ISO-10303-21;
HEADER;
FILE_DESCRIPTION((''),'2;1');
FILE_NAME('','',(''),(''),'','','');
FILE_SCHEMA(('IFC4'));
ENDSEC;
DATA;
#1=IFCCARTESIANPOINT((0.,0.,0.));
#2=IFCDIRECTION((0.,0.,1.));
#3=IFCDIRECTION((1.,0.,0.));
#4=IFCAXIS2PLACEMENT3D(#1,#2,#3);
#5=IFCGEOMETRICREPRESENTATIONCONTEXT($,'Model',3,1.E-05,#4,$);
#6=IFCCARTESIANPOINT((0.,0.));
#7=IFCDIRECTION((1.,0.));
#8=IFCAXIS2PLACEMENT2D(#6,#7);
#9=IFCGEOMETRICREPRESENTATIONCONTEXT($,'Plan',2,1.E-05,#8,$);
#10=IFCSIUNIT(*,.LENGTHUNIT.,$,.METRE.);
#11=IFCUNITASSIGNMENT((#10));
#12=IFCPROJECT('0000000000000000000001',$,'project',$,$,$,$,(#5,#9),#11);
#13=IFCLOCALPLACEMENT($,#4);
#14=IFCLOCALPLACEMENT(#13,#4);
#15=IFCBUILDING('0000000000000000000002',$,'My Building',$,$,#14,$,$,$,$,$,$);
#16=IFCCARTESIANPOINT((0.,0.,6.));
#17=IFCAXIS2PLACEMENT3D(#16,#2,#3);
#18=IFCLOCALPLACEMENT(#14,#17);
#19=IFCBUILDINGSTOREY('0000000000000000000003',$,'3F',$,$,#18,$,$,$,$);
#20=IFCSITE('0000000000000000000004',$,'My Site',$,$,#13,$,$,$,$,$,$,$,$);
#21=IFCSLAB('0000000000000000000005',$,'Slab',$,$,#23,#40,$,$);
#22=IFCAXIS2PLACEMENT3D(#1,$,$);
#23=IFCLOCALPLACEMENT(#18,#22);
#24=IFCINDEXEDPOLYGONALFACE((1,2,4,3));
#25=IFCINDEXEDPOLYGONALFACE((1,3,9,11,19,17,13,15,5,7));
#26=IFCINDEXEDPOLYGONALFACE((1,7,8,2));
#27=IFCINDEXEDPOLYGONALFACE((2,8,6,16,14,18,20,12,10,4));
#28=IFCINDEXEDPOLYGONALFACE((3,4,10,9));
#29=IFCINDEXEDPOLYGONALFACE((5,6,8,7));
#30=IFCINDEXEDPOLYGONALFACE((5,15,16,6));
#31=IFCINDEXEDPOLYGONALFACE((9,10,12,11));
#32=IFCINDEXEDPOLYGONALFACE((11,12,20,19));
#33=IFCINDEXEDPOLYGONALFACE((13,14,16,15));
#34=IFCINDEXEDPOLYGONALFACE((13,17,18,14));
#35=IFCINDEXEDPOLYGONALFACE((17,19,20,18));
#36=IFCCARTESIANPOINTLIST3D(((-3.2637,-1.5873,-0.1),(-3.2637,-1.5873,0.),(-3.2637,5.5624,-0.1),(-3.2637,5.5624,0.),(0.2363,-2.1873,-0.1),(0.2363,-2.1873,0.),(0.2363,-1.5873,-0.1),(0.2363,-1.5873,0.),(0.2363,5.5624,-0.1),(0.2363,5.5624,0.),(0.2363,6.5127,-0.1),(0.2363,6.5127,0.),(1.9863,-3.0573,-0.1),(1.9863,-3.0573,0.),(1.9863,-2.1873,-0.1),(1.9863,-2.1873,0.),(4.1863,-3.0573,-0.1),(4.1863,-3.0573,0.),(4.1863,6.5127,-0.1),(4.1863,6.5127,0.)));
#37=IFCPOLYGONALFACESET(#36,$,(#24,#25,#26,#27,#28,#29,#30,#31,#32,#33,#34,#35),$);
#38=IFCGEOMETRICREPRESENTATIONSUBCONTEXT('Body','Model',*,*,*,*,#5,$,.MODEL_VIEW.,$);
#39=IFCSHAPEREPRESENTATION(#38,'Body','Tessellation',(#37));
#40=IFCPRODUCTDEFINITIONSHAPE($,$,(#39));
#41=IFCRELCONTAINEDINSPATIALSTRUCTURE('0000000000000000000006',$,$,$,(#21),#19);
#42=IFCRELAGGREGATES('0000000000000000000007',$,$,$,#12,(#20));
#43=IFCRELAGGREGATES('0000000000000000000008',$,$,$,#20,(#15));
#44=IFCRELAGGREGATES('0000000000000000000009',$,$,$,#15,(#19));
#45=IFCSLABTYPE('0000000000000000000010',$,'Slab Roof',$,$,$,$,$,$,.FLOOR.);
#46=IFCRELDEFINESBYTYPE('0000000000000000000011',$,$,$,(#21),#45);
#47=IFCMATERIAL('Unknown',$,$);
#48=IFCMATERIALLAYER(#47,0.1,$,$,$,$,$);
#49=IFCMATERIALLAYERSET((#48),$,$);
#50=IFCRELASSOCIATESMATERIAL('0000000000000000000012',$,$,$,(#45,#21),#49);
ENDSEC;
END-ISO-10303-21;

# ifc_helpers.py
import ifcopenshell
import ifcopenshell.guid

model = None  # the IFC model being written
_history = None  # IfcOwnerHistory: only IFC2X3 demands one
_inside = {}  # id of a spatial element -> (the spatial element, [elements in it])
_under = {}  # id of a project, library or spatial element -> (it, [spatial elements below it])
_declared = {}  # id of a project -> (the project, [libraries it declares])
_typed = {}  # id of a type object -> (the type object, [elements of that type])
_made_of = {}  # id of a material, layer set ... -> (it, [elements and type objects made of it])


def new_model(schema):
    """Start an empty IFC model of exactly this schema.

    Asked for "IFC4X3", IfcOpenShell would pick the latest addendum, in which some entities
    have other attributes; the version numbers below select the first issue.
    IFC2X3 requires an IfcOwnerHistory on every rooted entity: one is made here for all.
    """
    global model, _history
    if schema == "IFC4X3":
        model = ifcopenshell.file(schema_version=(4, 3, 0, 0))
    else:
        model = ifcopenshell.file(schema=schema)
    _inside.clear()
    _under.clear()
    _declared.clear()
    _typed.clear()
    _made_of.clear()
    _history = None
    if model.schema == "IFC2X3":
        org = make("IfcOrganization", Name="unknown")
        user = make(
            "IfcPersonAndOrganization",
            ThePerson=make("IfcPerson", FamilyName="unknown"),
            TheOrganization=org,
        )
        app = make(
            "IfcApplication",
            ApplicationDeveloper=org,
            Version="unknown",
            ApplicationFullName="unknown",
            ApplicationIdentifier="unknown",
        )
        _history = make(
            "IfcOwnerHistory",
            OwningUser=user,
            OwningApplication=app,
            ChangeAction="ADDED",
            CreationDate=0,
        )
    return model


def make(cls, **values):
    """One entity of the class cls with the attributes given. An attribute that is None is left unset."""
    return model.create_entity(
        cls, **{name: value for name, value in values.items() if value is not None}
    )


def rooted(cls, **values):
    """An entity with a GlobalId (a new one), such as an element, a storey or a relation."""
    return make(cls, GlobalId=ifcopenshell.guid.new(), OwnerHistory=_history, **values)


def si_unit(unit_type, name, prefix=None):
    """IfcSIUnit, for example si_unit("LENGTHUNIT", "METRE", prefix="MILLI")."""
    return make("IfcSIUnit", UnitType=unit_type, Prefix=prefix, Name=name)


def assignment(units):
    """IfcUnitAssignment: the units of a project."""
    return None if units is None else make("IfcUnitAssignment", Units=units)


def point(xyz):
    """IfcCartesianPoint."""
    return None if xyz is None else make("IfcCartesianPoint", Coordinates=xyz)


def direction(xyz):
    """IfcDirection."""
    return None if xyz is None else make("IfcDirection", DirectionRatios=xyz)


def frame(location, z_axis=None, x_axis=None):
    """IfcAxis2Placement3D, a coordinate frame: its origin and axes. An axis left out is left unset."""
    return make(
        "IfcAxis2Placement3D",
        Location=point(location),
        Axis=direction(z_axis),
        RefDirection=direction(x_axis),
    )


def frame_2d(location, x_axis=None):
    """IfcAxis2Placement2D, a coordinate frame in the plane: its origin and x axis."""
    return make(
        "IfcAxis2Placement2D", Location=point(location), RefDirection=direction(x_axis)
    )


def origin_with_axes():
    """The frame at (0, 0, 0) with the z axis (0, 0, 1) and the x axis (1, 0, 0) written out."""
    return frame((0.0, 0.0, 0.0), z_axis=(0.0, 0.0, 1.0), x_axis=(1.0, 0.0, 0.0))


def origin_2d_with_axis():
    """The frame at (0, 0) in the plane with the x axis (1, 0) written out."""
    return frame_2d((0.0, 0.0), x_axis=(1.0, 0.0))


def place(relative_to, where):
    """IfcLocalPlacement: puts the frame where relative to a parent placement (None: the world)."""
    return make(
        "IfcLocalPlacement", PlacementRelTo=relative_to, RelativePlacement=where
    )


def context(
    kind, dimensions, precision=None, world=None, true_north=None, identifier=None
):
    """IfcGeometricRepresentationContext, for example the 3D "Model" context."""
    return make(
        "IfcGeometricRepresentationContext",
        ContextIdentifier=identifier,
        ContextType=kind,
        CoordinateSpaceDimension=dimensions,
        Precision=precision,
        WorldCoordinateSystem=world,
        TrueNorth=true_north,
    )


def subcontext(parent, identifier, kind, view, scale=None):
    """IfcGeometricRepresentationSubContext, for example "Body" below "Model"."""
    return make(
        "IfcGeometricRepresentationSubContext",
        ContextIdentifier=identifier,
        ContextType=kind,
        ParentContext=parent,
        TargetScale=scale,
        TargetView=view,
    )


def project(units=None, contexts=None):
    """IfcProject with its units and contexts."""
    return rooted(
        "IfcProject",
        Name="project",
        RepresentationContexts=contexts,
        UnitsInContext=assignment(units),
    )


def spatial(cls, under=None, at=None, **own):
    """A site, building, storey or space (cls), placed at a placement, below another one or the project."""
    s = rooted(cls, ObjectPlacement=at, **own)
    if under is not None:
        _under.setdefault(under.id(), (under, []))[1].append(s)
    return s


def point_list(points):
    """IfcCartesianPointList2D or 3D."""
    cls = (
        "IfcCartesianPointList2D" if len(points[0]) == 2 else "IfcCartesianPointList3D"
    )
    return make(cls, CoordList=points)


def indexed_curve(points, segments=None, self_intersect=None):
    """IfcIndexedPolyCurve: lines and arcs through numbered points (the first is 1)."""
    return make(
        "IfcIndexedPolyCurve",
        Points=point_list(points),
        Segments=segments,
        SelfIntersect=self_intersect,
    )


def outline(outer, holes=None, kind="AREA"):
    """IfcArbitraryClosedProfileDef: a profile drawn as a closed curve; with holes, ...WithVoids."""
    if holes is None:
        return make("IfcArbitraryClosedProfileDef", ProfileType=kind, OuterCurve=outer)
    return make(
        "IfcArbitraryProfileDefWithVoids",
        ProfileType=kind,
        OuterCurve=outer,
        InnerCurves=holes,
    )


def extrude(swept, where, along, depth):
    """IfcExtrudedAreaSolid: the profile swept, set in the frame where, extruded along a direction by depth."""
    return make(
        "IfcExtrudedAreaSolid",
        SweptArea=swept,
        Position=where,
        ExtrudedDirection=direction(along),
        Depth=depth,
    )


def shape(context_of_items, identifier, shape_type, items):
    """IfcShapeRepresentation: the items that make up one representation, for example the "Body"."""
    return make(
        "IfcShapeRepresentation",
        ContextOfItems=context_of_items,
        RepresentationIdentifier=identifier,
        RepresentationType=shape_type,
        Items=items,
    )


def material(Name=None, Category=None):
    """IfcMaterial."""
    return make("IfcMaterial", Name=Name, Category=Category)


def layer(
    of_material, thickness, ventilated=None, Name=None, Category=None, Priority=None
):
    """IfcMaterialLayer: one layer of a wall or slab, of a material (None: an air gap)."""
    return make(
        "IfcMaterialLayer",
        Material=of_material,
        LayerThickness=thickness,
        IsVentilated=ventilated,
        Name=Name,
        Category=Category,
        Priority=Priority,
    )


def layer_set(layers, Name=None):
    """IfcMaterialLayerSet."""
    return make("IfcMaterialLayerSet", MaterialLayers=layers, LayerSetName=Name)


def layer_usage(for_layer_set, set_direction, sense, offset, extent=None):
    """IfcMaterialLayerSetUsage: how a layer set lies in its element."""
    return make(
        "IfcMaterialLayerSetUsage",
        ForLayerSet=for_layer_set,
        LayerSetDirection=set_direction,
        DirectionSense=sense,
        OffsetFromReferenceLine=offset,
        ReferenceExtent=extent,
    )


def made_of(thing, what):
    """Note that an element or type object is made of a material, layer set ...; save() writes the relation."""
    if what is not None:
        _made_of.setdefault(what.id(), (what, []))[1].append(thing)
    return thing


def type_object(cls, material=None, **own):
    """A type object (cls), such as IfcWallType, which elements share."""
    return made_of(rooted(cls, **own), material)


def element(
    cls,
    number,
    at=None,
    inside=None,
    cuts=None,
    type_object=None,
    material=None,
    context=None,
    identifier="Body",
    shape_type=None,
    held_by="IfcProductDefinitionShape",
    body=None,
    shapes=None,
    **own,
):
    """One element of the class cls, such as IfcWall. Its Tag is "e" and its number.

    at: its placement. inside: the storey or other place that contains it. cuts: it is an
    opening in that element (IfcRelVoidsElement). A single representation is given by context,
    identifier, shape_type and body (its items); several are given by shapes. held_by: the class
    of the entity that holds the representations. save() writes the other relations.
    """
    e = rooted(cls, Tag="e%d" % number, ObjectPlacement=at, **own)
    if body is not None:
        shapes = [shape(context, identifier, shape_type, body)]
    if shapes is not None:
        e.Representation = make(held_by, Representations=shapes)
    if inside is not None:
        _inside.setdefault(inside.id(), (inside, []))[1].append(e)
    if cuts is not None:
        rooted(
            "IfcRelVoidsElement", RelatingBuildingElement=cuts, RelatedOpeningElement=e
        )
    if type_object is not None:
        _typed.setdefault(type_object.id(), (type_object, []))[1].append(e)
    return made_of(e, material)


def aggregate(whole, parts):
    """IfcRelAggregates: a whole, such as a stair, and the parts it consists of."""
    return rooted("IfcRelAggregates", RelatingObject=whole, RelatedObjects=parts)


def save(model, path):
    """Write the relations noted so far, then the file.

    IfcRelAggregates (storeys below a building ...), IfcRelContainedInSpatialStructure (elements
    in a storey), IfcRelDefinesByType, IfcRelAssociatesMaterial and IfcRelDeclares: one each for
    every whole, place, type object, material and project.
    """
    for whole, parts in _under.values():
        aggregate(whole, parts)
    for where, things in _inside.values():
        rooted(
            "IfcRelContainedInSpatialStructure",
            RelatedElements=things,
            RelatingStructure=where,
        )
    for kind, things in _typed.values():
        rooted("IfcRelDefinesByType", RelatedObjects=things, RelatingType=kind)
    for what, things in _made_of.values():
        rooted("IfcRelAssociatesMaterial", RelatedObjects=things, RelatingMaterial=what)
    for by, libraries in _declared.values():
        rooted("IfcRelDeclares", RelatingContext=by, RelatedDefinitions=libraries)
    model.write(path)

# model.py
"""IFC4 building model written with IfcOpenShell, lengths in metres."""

from ifc_helpers import new_model, si_unit, frame, origin_with_axes, origin_2d_with_axis, place, context, subcontext, project, spatial, indexed_curve, outline, extrude, material, layer, layer_set, layer_usage, type_object, element, save


model = new_model("IFC4")

# Units and contexts
model_context = context("Model", 3, precision=1e-05, world=origin_with_axes())
plan_context = context("Plan", 2, precision=1e-05, world=origin_2d_with_axis())
body_context = subcontext(model_context, "Body", "Model", "MODEL_VIEW")
ifc_project = project(units=[si_unit("LENGTHUNIT", "METRE")], contexts=[model_context, plan_context])

# Site, building, storey
site_placement = place(None, origin_with_axes())
site = spatial("IfcSite", under=ifc_project, at=site_placement, Name="My Site")
building_placement = place(site_placement, origin_with_axes())
building = spatial("IfcBuilding", under=site, at=building_placement, Name="My Building")
storey_placement = place(building_placement, frame((0.0, 0.0, 6.0), z_axis=(0.0, 0.0, 1.0), x_axis=(1.0, 0.0, 0.0)))
storey = spatial("IfcBuildingStorey", under=building, at=storey_placement, Name="3F")

# Slab
ifc_material = material(Name="Unknown")
ifc_layer = layer(ifc_material, 0.1)
ifc_layer_set = layer_set([ifc_layer])
ifc_layer_usage = layer_usage(ifc_layer_set, "AXIS3", "POSITIVE", -0.1)
slab_type = type_object("IfcSlabType", Name="Slab Roof", PredefinedType="FLOOR", material=ifc_layer_set)
slab_placement = place(storey_placement, frame((4.1863, -3.0573, 0.0), z_axis=(0.0, 0.0, 1.0), x_axis=(1.0, 0.0, 0.0)))
element("IfcSlab", 1, at=slab_placement, inside=storey, type_object=slab_type, material=ifc_layer_usage, Name="Slab", context=body_context, shape_type="SweptSolid", body=[
    extrude(outline(indexed_curve([(0.0, 0.0), (0.0, 9.57), (-3.95, 9.57), (-3.95, 8.6197), (-7.45, 8.6197), (-7.45, 1.47), (-3.95, 1.47), (-3.95, 0.87), (-2.2, 0.87), (-2.2, 0.0), (0.0, 0.0)])), frame((0.0, 0.0, -0.1), z_axis=(0.0, 0.0, 1.0), x_axis=(1.0, 0.0, 0.0)), (0.0, 0.0, 1.0), 0.1),
])

save(model, "model.ifc")
